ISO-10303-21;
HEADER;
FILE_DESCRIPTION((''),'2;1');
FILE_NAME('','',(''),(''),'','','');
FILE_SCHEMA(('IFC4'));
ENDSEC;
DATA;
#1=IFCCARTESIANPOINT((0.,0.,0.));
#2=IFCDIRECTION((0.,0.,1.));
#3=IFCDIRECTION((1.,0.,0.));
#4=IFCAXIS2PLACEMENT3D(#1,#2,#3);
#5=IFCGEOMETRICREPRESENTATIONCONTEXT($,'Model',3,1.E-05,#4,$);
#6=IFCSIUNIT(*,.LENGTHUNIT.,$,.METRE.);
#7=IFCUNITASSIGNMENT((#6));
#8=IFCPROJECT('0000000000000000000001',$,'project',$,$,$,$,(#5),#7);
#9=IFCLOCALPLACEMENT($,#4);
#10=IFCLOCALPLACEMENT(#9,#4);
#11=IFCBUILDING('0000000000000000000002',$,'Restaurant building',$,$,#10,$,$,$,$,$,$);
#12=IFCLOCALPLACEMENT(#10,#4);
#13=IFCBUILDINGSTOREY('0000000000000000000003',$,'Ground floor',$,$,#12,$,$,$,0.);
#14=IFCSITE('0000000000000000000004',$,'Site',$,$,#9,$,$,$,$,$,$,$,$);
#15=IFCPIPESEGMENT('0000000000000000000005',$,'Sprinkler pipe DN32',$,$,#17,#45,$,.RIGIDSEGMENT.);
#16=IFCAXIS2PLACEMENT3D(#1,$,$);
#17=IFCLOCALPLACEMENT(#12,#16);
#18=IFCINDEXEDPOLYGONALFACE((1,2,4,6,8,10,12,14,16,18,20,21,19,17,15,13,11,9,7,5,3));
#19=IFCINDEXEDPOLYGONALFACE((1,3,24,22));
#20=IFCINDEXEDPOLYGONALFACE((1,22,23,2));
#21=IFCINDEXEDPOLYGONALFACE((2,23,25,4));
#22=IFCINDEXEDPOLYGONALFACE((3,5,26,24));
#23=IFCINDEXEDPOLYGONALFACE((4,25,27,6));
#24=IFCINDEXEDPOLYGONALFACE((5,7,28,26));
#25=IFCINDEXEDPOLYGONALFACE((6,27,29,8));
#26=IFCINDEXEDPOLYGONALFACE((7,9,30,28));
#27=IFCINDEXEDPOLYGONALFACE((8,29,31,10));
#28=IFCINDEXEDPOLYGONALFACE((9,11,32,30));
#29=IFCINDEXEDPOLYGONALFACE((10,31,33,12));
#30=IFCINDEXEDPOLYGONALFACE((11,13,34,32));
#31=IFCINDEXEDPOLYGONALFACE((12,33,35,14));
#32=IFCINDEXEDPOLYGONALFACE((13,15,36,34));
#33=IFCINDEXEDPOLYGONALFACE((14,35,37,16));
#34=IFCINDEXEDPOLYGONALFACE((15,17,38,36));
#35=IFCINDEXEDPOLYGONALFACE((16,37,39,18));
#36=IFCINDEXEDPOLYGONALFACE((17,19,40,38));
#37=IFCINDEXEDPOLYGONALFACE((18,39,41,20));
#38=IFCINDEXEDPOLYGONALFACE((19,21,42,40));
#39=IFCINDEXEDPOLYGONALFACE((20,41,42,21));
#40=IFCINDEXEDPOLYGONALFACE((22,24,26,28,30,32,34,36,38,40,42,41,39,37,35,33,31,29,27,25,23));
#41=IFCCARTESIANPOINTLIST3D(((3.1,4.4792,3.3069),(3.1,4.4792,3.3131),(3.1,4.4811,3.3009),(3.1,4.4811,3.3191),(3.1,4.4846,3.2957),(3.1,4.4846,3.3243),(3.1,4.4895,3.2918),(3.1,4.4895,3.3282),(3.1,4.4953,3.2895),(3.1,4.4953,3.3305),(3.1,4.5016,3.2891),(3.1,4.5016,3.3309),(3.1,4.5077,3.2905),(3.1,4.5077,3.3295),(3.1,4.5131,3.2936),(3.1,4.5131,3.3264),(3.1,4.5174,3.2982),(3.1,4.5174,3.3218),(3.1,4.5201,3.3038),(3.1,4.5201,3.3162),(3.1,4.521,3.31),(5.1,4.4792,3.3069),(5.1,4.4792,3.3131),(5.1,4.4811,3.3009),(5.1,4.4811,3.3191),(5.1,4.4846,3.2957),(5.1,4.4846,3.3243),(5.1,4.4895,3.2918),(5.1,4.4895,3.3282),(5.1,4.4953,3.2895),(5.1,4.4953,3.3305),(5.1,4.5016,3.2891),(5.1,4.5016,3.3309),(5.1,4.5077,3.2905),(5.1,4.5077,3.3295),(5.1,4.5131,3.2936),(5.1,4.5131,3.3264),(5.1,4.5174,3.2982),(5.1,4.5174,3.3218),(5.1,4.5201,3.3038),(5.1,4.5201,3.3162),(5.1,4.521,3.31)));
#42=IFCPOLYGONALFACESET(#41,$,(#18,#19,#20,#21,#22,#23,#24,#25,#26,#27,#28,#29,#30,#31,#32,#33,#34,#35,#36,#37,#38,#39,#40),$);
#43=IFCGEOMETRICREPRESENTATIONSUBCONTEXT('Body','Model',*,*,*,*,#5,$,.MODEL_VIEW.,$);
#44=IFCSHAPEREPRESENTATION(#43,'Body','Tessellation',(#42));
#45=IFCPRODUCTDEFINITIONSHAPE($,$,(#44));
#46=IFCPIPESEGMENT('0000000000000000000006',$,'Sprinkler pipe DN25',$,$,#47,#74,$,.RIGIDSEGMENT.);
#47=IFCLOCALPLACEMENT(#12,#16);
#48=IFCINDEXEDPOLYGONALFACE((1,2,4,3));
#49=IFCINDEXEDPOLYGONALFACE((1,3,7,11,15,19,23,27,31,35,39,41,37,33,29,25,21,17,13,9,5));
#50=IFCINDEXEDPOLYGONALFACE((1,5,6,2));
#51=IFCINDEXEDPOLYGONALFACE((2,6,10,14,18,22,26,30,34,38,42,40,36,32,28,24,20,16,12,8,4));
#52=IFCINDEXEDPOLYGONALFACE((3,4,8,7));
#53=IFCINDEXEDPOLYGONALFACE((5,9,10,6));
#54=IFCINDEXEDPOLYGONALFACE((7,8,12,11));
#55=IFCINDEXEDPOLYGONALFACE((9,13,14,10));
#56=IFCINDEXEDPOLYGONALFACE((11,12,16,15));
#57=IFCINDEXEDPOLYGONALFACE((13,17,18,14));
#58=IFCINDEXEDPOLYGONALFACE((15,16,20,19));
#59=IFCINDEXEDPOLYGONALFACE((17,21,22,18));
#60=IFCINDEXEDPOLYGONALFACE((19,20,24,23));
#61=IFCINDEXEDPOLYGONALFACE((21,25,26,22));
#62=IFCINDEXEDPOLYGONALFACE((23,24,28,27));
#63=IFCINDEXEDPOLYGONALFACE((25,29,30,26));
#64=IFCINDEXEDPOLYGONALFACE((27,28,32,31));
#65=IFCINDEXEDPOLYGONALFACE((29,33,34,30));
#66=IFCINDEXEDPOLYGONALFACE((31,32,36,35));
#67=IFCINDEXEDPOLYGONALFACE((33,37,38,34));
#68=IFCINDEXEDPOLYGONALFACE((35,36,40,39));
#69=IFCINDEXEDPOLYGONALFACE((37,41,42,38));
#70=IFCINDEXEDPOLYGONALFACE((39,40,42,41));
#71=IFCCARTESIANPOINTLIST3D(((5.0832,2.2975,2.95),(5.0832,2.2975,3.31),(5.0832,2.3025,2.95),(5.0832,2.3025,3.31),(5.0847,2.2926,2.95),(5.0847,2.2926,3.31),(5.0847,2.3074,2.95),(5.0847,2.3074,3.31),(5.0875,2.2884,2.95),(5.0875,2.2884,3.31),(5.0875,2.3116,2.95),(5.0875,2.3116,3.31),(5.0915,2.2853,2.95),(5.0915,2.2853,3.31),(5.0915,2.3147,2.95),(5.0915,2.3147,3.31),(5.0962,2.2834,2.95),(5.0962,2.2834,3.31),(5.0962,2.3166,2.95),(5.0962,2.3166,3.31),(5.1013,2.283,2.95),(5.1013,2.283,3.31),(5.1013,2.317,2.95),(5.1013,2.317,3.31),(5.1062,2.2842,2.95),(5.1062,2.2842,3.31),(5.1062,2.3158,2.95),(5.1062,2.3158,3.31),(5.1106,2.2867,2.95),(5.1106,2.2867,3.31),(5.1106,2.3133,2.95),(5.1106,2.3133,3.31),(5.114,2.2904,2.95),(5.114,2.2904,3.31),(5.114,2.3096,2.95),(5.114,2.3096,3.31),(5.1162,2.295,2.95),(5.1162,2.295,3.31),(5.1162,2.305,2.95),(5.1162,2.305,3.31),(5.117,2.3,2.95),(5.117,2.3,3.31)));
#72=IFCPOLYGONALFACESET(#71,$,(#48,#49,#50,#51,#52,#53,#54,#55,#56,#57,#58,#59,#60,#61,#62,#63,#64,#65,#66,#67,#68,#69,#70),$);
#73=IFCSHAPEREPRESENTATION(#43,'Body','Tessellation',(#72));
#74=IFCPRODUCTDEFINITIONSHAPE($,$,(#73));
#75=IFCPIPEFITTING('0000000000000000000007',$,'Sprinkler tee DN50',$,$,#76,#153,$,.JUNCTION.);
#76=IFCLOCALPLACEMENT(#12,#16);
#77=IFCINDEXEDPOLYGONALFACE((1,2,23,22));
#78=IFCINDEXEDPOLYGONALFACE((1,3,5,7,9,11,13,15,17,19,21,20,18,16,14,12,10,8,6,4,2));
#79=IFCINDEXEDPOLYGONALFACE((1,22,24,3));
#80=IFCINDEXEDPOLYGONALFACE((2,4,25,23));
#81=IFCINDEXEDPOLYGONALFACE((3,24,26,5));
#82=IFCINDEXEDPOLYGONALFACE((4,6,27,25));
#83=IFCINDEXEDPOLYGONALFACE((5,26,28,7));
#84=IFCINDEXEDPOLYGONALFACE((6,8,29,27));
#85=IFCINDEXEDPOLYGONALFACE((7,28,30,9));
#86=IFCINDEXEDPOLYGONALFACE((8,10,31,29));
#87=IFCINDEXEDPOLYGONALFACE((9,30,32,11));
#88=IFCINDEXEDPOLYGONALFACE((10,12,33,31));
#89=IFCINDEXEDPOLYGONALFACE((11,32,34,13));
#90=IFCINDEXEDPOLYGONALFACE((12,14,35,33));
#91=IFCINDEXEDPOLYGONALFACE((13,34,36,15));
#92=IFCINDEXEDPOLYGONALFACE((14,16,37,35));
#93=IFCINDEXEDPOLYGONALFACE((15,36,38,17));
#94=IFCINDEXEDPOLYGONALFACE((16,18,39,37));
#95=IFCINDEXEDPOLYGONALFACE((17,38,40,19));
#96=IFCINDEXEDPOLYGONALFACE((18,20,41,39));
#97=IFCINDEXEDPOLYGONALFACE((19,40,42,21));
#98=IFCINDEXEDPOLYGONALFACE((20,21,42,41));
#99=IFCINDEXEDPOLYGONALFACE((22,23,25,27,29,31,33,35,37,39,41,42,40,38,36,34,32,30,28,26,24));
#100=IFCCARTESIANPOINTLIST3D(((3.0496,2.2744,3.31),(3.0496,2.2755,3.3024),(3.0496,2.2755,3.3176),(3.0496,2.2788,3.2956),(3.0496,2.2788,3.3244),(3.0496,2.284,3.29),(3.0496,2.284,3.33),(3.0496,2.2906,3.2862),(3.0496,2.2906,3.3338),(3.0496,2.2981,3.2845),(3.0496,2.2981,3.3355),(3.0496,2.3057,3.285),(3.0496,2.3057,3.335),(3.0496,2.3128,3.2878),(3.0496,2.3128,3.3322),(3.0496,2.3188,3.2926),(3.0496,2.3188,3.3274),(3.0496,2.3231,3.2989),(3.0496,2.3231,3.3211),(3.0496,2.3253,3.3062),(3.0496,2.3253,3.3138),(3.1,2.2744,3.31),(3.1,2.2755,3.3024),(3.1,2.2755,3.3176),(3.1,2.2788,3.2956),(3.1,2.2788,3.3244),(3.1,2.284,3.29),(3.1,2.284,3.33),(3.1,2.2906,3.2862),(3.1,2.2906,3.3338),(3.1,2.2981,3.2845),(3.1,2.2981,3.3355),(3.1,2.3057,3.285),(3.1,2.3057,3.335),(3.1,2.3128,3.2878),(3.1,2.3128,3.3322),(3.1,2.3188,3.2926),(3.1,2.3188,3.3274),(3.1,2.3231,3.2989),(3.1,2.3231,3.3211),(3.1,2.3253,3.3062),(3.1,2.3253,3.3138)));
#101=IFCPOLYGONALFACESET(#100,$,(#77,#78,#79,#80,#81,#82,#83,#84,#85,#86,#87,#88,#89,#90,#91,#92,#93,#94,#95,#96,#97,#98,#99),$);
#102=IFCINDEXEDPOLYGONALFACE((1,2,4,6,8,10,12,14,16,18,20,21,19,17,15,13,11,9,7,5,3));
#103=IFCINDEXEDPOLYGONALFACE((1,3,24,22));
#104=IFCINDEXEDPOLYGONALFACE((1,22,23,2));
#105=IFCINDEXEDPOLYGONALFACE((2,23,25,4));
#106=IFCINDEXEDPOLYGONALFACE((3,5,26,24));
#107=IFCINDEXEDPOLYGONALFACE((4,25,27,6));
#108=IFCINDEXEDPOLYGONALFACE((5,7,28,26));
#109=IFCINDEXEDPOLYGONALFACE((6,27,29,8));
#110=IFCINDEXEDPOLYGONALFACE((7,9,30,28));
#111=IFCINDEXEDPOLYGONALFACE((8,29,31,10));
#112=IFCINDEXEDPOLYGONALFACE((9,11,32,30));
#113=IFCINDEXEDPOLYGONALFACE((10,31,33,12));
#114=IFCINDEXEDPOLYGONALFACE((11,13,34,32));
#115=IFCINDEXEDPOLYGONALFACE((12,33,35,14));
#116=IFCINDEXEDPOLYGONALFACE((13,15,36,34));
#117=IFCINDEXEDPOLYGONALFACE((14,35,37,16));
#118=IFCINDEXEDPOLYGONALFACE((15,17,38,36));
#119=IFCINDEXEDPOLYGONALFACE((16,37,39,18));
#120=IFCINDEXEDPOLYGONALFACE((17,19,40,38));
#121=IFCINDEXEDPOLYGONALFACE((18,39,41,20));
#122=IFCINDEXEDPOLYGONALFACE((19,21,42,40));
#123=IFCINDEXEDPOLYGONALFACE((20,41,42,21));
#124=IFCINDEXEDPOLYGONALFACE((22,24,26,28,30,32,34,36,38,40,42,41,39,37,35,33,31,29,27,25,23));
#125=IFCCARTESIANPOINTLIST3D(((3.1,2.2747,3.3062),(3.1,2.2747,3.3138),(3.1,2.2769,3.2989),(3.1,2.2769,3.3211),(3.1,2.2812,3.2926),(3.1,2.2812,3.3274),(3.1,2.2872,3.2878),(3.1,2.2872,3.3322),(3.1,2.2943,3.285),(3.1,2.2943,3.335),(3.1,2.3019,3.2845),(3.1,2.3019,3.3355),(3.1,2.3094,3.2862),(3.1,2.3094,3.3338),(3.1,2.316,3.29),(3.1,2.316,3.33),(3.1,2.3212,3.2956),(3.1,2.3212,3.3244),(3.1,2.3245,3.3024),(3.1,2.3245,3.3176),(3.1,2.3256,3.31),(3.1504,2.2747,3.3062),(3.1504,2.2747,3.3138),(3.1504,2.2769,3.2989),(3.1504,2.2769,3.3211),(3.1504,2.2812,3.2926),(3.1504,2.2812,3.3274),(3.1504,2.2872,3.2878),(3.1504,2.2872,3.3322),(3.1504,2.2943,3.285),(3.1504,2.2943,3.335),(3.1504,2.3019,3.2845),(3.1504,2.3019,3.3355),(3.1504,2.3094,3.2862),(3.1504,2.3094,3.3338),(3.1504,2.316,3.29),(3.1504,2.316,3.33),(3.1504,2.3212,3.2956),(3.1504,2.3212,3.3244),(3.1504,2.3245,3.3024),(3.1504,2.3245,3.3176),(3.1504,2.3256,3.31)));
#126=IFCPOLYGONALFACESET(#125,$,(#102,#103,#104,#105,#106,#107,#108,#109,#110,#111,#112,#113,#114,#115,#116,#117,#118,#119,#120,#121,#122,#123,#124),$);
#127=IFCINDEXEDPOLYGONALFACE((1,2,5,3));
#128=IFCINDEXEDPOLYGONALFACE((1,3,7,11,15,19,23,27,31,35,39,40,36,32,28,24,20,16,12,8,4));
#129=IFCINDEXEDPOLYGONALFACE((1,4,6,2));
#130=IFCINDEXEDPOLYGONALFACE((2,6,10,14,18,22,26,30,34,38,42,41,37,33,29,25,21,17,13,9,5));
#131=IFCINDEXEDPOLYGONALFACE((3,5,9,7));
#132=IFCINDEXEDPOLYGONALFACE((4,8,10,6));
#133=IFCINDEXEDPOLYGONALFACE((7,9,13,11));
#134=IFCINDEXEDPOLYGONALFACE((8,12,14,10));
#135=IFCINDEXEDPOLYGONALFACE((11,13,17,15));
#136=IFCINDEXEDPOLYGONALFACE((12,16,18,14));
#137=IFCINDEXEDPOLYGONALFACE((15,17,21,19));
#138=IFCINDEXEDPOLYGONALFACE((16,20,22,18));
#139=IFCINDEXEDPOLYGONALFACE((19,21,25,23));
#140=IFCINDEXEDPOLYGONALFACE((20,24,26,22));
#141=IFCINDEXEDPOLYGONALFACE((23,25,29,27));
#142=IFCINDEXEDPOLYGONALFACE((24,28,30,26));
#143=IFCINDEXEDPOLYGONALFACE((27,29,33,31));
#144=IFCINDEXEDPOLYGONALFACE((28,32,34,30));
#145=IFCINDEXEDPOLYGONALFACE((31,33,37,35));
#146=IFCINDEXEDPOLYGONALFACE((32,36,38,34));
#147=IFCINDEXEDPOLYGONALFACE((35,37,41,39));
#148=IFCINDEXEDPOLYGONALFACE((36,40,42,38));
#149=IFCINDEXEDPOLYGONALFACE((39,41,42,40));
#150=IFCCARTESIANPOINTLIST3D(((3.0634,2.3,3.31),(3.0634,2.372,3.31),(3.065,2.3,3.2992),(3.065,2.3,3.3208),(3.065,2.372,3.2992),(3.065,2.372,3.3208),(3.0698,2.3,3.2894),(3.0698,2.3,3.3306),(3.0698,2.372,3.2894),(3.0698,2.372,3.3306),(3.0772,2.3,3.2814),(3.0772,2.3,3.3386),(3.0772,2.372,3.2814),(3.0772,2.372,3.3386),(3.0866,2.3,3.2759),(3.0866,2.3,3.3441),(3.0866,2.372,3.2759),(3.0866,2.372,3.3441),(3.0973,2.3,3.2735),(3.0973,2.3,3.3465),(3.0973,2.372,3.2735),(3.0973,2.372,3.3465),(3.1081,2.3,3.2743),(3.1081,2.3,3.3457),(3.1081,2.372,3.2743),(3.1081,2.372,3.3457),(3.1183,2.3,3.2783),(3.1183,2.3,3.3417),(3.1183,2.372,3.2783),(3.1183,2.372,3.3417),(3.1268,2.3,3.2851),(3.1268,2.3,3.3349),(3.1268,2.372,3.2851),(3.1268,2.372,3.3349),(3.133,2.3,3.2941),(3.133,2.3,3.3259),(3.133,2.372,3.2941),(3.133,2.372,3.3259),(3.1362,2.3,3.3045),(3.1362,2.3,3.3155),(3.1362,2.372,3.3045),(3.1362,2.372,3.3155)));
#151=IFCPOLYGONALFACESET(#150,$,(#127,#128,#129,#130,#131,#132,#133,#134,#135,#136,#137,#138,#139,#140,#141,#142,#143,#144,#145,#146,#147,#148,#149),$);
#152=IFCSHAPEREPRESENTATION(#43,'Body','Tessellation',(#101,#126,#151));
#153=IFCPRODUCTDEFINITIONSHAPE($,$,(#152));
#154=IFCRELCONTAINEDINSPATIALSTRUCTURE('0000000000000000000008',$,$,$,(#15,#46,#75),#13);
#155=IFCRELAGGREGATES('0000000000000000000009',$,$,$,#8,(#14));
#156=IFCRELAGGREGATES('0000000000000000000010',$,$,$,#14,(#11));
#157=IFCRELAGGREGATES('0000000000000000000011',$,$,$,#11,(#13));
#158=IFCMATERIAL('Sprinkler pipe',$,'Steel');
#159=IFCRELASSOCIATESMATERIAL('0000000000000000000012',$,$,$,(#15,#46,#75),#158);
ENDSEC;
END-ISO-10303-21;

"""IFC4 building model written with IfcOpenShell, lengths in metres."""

from ifc_helpers import new_model, si_unit, frame, origin_with_axes, origin_2d, place, context, subcontext, project, spatial, circle, extrude, material, element, save


model = new_model("IFC4")

# Units and contexts
model_context = context("Model", 3, precision=1e-05, world=origin_with_axes())
body_context = subcontext(model_context, "Body", "Model", "MODEL_VIEW")
ifc_project = project(units=[si_unit("LENGTHUNIT", "METRE")], contexts=[model_context])

# Site, building, storey
site_placement = place(None, origin_with_axes())
site = spatial("IfcSite", under=ifc_project, at=site_placement, Name="Site")
building_placement = place(site_placement, origin_with_axes())
building = spatial("IfcBuilding", under=site, at=building_placement, Name="Restaurant building")
storey_placement = place(building_placement, origin_with_axes())
storey = spatial("IfcBuildingStorey", under=building, at=storey_placement, Name="Ground floor", Elevation=0.0)

# Pipe segments
ifc_material_1 = material(Name="Sprinkler pipe", Category="Steel")
pipe_segment_1_placement = place(storey_placement, frame((3.1, 4.5, 3.31)))
element("IfcPipeSegment", 1, at=pipe_segment_1_placement, inside=storey, material=ifc_material_1, Name="Sprinkler pipe DN32", PredefinedType="RIGIDSEGMENT", context=body_context, shape_type="SweptSolid", body=[
    extrude(circle(Radius=0.021, at=origin_2d()), frame((0.0, 0.0, 0.0), z_axis=(1.0, 0.0, 0.0), x_axis=(0.0, 1.0, 0.0)), (0.0, 0.0, 1.0), 2.0),
])
pipe_segment_2_placement = place(storey_placement, frame((5.1, 2.3, 3.31)))
element("IfcPipeSegment", 2, at=pipe_segment_2_placement, inside=storey, material=ifc_material_1, Name="Sprinkler pipe DN25", PredefinedType="RIGIDSEGMENT", context=body_context, shape_type="SweptSolid", body=[
    extrude(circle(Radius=0.017, at=origin_2d()), frame((0.0, 0.0, 0.0), z_axis=(0.0, 0.0, -1.0), x_axis=(1.0, 0.0, 0.0)), (0.0, 0.0, 1.0), 0.36),
])

# Pipe fitting
pipe_fitting_1_placement = place(storey_placement, frame((3.1, 2.3, 3.31)))
element("IfcPipeFitting", 3, at=pipe_fitting_1_placement, inside=storey, material=ifc_material_1, Name="Sprinkler tee DN50", PredefinedType="JUNCTION", context=body_context, shape_type="SweptSolid", body=[
    extrude(circle(Radius=0.0256, at=origin_2d()), frame((0.0, 0.0, 0.0), z_axis=(-1.0, 0.0, 0.0), x_axis=(0.0, -1.0, 0.0)), (0.0, 0.0, 1.0), 0.0504),
    extrude(circle(Radius=0.0256, at=origin_2d()), frame((0.0, 0.0, 0.0), z_axis=(1.0, 0.0, 0.0), x_axis=(0.0, 1.0, 0.0)), (0.0, 0.0, 1.0), 0.0504),
    extrude(circle(Radius=0.0366, at=origin_2d()), frame((0.0, 0.0, 0.0), z_axis=(0.0, 1.0, 0.0), x_axis=(-1.0, 0.0, 0.0)), (0.0, 0.0, 1.0), 0.072),
])

save(model, "model.ifc")
